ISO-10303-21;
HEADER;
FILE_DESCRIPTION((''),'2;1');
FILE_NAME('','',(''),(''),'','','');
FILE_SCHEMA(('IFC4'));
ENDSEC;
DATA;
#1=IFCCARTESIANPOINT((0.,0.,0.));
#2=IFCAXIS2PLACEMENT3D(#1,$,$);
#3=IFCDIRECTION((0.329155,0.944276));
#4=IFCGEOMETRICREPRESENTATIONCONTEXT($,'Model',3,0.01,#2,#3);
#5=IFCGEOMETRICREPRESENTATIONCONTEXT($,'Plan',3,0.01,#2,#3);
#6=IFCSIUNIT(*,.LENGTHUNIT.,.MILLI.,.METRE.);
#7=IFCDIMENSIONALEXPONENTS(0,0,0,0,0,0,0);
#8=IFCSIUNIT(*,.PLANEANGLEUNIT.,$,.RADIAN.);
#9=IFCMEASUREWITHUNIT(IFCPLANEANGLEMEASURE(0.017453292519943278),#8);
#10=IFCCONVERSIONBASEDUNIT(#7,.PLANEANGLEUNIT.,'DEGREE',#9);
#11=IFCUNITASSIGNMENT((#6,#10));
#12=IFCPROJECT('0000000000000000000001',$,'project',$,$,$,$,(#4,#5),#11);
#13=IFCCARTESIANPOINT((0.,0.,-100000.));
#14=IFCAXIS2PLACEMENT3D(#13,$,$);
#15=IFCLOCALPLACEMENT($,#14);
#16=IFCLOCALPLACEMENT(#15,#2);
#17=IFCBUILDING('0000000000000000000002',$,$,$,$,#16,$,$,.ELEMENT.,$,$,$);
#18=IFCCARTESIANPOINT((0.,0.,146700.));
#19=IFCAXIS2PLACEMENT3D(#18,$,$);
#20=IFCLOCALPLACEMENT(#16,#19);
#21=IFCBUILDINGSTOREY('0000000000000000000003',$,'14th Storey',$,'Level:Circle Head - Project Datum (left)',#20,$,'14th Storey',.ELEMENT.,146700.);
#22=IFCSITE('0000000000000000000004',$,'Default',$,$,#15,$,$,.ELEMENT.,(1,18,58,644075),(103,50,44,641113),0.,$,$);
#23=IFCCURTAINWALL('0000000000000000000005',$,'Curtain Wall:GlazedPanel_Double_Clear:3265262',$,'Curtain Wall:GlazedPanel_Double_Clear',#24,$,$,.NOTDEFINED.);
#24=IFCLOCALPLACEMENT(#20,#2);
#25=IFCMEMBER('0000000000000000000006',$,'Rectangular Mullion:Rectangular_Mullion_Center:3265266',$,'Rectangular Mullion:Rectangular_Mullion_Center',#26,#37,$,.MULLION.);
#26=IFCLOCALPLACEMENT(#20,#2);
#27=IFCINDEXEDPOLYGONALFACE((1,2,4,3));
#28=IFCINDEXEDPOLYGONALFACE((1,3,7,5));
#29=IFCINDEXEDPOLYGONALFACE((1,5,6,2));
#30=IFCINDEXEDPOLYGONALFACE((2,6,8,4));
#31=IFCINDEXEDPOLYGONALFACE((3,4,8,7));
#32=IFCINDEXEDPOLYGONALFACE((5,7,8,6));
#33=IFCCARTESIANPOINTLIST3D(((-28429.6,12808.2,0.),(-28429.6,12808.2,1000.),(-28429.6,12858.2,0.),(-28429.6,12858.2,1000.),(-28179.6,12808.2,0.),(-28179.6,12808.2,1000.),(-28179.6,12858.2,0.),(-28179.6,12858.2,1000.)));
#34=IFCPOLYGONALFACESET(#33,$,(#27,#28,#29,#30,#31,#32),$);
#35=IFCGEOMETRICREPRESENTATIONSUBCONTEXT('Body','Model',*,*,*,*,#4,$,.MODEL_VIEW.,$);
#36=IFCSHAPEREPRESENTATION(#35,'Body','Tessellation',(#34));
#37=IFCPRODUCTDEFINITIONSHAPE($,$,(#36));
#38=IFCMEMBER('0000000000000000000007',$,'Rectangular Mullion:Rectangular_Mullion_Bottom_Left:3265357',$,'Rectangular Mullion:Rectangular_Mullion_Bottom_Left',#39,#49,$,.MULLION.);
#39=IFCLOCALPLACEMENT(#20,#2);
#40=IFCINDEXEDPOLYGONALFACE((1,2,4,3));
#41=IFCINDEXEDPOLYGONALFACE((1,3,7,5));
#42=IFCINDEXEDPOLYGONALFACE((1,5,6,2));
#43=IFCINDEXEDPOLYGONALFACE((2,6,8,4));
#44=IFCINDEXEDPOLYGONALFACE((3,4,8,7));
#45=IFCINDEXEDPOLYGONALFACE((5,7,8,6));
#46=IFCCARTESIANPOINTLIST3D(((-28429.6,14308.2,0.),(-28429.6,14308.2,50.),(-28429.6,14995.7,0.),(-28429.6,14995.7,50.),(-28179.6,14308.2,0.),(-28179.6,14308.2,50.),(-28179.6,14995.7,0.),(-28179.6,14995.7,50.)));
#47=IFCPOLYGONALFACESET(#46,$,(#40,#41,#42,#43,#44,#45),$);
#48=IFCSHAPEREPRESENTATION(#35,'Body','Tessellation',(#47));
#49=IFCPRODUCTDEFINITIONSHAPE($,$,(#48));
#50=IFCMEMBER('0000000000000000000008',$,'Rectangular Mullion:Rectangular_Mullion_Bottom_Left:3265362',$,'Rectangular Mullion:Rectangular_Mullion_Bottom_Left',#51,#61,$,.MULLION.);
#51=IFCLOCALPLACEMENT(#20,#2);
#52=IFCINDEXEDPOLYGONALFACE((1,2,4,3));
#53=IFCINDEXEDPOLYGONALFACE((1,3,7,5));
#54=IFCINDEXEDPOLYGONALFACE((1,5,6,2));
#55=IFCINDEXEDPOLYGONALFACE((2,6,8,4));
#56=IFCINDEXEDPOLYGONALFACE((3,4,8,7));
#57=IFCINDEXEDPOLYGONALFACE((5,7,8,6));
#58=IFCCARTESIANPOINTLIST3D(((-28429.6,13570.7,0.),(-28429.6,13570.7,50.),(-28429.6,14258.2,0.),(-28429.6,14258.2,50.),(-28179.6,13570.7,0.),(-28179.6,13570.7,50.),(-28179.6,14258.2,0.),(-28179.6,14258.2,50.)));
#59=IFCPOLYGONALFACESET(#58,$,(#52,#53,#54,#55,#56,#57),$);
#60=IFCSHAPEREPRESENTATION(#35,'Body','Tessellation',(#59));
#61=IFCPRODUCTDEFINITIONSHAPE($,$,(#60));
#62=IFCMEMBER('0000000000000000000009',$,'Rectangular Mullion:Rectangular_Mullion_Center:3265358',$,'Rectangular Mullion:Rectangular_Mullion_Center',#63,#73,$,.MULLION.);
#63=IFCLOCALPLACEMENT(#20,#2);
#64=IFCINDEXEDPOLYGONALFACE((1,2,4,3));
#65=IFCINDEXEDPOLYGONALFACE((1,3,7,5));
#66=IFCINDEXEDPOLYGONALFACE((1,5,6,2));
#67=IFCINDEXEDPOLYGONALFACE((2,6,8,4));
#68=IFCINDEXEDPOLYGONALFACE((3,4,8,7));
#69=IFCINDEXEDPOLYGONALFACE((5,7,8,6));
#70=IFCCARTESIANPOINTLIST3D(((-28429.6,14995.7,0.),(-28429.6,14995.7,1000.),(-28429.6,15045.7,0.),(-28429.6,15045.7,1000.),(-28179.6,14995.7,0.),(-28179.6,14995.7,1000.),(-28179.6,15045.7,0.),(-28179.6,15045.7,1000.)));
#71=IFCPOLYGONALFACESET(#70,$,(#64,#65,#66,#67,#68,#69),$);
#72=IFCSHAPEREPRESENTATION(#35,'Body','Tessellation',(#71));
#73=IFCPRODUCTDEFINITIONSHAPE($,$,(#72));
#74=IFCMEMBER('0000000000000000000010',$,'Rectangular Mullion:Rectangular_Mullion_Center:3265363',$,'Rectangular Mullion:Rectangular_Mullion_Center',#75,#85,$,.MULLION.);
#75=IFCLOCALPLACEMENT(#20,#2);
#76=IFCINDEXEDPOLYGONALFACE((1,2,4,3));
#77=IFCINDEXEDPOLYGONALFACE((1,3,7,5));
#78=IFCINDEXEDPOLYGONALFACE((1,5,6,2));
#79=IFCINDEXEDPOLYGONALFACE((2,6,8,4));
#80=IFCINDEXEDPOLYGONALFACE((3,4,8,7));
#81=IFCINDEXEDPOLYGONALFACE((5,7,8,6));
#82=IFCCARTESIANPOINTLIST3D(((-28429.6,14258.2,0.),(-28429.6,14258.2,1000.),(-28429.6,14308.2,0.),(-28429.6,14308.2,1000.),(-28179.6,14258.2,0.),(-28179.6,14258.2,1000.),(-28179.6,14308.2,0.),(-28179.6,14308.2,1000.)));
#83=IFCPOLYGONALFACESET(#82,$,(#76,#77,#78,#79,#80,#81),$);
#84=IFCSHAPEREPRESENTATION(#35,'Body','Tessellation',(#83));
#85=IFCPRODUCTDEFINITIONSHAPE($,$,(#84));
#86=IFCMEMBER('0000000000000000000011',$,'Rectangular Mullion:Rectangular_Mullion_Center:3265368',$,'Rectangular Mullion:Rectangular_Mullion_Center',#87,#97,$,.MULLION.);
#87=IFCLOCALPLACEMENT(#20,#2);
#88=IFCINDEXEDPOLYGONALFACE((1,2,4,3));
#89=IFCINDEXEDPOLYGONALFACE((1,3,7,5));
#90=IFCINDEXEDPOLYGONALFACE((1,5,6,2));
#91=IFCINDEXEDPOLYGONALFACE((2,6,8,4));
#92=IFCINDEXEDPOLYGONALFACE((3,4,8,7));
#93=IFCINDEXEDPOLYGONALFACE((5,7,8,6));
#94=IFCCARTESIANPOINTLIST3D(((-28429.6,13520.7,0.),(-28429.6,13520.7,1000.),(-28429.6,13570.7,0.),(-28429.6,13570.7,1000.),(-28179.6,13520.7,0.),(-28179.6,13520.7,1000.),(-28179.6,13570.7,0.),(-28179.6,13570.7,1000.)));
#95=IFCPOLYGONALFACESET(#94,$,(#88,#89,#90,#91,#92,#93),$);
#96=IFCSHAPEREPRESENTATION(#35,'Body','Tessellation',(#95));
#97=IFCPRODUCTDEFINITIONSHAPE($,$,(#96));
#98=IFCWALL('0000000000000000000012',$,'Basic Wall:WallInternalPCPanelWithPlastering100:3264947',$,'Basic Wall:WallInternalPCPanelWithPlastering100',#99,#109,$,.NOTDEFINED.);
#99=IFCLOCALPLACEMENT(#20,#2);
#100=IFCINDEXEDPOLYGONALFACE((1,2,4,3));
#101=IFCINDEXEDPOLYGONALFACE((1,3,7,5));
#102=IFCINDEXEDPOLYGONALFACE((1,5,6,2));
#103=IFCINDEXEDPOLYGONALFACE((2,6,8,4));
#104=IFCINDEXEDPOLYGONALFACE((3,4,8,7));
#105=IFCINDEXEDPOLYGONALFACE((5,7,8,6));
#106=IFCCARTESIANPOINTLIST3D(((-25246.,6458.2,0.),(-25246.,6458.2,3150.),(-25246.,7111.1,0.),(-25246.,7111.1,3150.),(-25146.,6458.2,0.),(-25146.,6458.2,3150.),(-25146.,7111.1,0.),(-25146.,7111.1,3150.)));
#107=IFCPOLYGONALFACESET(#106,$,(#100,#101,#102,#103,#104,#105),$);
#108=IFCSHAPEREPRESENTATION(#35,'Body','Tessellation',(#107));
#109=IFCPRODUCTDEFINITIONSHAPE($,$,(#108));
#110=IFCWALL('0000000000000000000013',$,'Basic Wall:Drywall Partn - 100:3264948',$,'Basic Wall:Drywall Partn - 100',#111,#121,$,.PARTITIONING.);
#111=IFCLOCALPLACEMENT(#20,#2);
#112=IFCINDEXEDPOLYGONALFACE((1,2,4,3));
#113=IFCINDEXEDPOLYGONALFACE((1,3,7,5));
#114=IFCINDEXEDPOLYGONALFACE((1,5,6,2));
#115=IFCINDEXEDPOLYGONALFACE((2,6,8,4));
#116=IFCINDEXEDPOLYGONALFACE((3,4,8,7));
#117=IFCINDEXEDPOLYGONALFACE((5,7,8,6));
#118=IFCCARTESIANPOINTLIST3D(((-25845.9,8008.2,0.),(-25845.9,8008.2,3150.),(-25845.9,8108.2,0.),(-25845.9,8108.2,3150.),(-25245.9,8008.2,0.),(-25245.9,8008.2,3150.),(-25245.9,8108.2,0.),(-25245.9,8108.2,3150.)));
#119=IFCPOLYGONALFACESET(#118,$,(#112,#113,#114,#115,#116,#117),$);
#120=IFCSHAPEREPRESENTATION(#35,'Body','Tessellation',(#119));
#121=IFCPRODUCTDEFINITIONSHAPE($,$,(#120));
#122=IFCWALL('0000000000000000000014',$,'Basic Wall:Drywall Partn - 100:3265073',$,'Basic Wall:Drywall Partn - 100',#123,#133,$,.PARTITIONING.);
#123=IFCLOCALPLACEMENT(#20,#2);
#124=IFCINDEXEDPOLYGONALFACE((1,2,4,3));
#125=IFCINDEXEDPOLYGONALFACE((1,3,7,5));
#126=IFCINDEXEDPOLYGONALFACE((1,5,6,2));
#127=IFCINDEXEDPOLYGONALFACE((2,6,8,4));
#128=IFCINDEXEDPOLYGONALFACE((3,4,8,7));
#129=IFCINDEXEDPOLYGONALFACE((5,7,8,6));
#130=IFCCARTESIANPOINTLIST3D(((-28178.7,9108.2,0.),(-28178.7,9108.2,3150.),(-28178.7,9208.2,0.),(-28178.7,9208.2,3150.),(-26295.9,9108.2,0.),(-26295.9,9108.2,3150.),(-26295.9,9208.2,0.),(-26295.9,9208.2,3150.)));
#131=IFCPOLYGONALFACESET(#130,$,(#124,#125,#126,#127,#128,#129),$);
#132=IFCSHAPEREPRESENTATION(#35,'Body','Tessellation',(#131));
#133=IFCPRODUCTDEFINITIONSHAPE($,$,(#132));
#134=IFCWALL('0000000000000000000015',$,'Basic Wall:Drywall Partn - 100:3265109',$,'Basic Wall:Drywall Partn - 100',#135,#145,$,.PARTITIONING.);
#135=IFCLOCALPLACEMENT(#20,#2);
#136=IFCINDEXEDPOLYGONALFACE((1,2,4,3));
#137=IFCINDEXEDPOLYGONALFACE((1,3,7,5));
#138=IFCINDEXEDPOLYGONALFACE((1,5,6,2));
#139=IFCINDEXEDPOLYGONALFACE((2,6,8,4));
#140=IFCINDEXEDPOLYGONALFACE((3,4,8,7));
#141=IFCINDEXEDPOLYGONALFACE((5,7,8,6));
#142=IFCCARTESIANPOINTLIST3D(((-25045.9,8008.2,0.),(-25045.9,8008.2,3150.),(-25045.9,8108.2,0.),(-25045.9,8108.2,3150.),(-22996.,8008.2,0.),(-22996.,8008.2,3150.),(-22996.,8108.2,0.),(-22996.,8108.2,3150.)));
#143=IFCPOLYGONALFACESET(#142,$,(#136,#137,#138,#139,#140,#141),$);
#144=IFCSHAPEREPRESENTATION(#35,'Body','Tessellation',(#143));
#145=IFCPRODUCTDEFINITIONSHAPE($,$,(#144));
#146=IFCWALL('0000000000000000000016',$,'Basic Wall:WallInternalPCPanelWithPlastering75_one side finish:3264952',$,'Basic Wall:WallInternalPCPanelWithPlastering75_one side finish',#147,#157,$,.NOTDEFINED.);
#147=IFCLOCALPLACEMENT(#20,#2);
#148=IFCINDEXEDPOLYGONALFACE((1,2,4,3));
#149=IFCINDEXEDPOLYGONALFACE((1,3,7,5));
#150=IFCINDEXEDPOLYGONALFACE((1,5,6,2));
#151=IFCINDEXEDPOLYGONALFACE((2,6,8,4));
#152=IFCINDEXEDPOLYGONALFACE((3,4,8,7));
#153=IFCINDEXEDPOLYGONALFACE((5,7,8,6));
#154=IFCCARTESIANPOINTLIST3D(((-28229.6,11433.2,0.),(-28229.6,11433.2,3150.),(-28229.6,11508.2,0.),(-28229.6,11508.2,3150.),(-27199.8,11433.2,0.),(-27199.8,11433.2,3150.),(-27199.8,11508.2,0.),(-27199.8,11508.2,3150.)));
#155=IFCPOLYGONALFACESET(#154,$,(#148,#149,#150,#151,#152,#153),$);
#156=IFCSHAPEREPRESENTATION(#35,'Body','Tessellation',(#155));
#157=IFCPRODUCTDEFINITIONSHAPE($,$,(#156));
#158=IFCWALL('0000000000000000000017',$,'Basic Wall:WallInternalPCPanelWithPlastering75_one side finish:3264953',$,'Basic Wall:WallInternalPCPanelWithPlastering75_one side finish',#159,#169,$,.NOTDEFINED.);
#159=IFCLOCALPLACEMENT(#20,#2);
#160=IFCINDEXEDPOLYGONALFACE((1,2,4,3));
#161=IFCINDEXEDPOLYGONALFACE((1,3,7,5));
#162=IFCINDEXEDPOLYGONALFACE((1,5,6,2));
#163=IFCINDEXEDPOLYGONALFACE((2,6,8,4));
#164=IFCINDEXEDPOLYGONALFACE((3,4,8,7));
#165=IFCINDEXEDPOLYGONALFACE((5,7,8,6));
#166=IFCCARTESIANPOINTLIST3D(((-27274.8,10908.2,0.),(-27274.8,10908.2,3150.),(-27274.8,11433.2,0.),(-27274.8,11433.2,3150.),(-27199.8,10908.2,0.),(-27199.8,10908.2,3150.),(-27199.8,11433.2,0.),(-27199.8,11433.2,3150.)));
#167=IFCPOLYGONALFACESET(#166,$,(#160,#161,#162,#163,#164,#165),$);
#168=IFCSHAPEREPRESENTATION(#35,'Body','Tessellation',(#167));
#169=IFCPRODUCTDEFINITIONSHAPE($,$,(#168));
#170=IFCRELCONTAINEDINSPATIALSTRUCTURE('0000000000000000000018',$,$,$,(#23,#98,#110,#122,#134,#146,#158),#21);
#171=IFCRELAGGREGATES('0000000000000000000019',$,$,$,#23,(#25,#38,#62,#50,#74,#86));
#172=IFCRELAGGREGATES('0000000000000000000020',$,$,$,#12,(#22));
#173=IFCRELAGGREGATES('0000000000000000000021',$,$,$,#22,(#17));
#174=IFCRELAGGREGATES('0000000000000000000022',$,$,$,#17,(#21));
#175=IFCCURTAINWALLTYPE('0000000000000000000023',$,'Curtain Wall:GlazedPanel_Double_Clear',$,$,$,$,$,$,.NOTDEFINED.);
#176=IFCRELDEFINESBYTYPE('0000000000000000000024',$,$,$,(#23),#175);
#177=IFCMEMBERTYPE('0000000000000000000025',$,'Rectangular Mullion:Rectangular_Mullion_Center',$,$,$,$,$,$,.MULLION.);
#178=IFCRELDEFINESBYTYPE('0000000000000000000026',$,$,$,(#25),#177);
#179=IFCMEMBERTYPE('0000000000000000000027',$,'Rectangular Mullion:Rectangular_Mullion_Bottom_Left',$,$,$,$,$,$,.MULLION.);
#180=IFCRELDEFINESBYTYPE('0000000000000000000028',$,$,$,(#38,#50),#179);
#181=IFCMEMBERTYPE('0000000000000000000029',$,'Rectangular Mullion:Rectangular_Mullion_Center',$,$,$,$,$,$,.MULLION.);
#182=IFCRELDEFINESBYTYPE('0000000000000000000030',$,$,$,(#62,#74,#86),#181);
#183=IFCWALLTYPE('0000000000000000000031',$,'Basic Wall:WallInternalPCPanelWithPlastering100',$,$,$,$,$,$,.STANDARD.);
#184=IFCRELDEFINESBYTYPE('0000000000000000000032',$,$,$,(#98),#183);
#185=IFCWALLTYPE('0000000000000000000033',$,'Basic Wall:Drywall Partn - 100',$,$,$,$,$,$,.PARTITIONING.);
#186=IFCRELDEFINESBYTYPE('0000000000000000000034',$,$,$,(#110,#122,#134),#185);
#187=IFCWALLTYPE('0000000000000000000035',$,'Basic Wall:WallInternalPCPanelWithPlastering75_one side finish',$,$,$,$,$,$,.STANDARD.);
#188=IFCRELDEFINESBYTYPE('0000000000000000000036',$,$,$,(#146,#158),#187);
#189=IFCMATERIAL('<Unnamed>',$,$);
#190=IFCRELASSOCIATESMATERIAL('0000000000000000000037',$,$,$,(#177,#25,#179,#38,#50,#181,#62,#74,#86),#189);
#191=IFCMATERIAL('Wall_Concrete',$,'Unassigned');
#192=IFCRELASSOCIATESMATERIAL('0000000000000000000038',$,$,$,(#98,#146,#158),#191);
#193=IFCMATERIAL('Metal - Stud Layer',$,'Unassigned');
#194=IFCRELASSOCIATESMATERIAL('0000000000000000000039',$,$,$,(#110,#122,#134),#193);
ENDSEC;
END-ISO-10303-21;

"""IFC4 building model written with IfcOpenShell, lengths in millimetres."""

from ifc_helpers import new_model, entity, si_unit, converted_unit, direction, frame, origin, place, context, subcontext, project, spatial, indexed_curve, outline, extrude, source, transform, mapped, material, type_object, type_shapes, element, aggregate, save


model = new_model("IFC4")

# Units and contexts
model_context = context("Model", 3, precision=0.01, world=origin(), true_north=direction((0.329155, 0.944276)))
plan_context = context("Plan", 3, precision=0.01, world=origin(), true_north=direction((0.329155, 0.944276)))
body_context = subcontext(model_context, "Body", "Model", "MODEL_VIEW")
ifc_project = project(units=[si_unit("LENGTHUNIT", "METRE", prefix="MILLI"), converted_unit("PLANEANGLEUNIT", "DEGREE", entity("IfcPlaneAngleMeasure", 0.017453292519943278), si_unit("PLANEANGLEUNIT", "RADIAN"), dimensions=[0, 0, 0, 0, 0, 0, 0])], contexts=[model_context, plan_context])

# Site, building, storey
site_placement = place(None, frame((0.0, 0.0, -100000.0)))
site = spatial("IfcSite", under=ifc_project, at=site_placement, Name="Default", CompositionType="ELEMENT", RefLatitude=(1, 18, 58, 644075), RefLongitude=(103, 50, 44, 641113), RefElevation=0.0)
building_placement = place(site_placement, origin())
building = spatial("IfcBuilding", under=site, at=building_placement, CompositionType="ELEMENT")
storey_placement = place(building_placement, frame((0.0, 0.0, 146700.0)))
storey = spatial("IfcBuildingStorey", under=building, at=storey_placement, Name="14th Storey", ObjectType="Level:Circle Head - Project Datum (left)", LongName="14th Storey", CompositionType="ELEMENT", Elevation=146700.0)

# Shared definitions
curtain_wall_type = type_object("IfcCurtainWallType", Name="Curtain Wall:GlazedPanel_Double_Clear", PredefinedType="NOTDEFINED")
ifc_material_1 = material(Name="<Unnamed>")

# Curtain wall, members
curtain_wall_1_placement = place(storey_placement, frame((0.0, 0.0, -146700.0)))
curtain_wall_1 = element("IfcCurtainWall", 1, at=curtain_wall_1_placement, inside=storey, type_object=curtain_wall_type, Name="Curtain Wall:GlazedPanel_Double_Clear:3265262", ObjectType="Curtain Wall:GlazedPanel_Double_Clear", PredefinedType="NOTDEFINED")
member_type_1 = type_object("IfcMemberType", Name="Rectangular Mullion:Rectangular_Mullion_Center", PredefinedType="MULLION", material=ifc_material_1)
shared_shape_1 = source(origin(), body_context, "Body", "SweptSolid", [
    extrude(outline(indexed_curve([(-25.0, -125.0), (25.0, -125.0), (25.0, 125.0), (-25.0, 125.0), (-25.0, -125.0)], self_intersect=False)), frame((-25.0, 0.0, -1000.0), z_axis=(0.0, 0.0, 1.0), x_axis=(-1.0, 0.0, 0.0)), (0.0, 0.0, 1.0), 1000.0),
])
type_shapes(member_type_1, [shared_shape_1])
member_1_placement = place(curtain_wall_1_placement, frame((-28304.6, 12808.2, 146700.0), z_axis=(0.0, 0.0, -1.0), x_axis=(0.0, -1.0, 0.0)))
member_1 = element("IfcMember", 2, at=member_1_placement, type_object=member_type_1, material=ifc_material_1, Name="Rectangular Mullion:Rectangular_Mullion_Center:3265266", ObjectType="Rectangular Mullion:Rectangular_Mullion_Center", PredefinedType="MULLION", context=body_context, shape_type="MappedRepresentation", body=[
    mapped(shared_shape_1, transform((0.0, 0.0, 0.0), scale=1.0)),
])
member_type_2 = type_object("IfcMemberType", Name="Rectangular Mullion:Rectangular_Mullion_Bottom_Left", PredefinedType="MULLION", material=ifc_material_1)
shared_shape_2 = source(origin(), body_context, "Body", "SweptSolid", [
    extrude(outline(indexed_curve([(-25.0, -125.0), (25.0, -125.0), (25.0, 125.0), (-25.0, 125.0), (-25.0, -125.0)], self_intersect=False)), frame((-25.0, 0.0, -687.5), z_axis=(0.0, 0.0, 1.0), x_axis=(-1.0, 0.0, 0.0)), (0.0, 0.0, 1.0), 687.5),
])
type_shapes(member_type_2, [shared_shape_2])
member_2_placement = place(curtain_wall_1_placement, frame((-28304.6, 14995.7, 146700.0), z_axis=(0.0, 1.0, 0.0), x_axis=(0.0, 0.0, -1.0)))
member_2 = element("IfcMember", 3, at=member_2_placement, type_object=member_type_2, material=ifc_material_1, Name="Rectangular Mullion:Rectangular_Mullion_Bottom_Left:3265357", ObjectType="Rectangular Mullion:Rectangular_Mullion_Bottom_Left", PredefinedType="MULLION", context=body_context, shape_type="MappedRepresentation", body=[
    mapped(shared_shape_2, transform((0.0, 0.0, 0.0), scale=1.0)),
])
member_3_placement = place(curtain_wall_1_placement, frame((-28304.6, 14258.2, 146700.0), z_axis=(0.0, 1.0, 0.0), x_axis=(0.0, 0.0, -1.0)))
member_3 = element("IfcMember", 4, at=member_3_placement, type_object=member_type_2, material=ifc_material_1, Name="Rectangular Mullion:Rectangular_Mullion_Bottom_Left:3265362", ObjectType="Rectangular Mullion:Rectangular_Mullion_Bottom_Left", PredefinedType="MULLION", context=body_context, shape_type="MappedRepresentation", body=[
    mapped(shared_shape_2, transform((0.0, 0.0, 0.0), scale=1.0)),
])
member_type_3 = type_object("IfcMemberType", Name="Rectangular Mullion:Rectangular_Mullion_Center", PredefinedType="MULLION", material=ifc_material_1)
shared_shape_3 = source(origin(), body_context, "Body", "SweptSolid", [
    extrude(outline(indexed_curve([(-25.0, -125.0), (25.0, -125.0), (25.0, 125.0), (-25.0, 125.0), (-25.0, -125.0)], self_intersect=False)), frame((0.0, 0.0, -1000.0), z_axis=(0.0, 0.0, 1.0), x_axis=(-1.0, 0.0, 0.0)), (0.0, 0.0, 1.0), 1000.0),
])
type_shapes(member_type_3, [shared_shape_3])
member_4_placement = place(curtain_wall_1_placement, frame((-28304.6, 15020.7, 146700.0), z_axis=(0.0, 0.0, -1.0), x_axis=(0.0, -1.0, 0.0)))
member_4 = element("IfcMember", 5, at=member_4_placement, type_object=member_type_3, material=ifc_material_1, Name="Rectangular Mullion:Rectangular_Mullion_Center:3265358", ObjectType="Rectangular Mullion:Rectangular_Mullion_Center", PredefinedType="MULLION", context=body_context, shape_type="MappedRepresentation", body=[
    mapped(shared_shape_3, transform((0.0, 0.0, 0.0), scale=1.0)),
])
member_5_placement = place(curtain_wall_1_placement, frame((-28304.6, 14283.2, 146700.0), z_axis=(0.0, 0.0, -1.0), x_axis=(0.0, -1.0, 0.0)))
member_5 = element("IfcMember", 6, at=member_5_placement, type_object=member_type_3, material=ifc_material_1, Name="Rectangular Mullion:Rectangular_Mullion_Center:3265363", ObjectType="Rectangular Mullion:Rectangular_Mullion_Center", PredefinedType="MULLION", context=body_context, shape_type="MappedRepresentation", body=[
    mapped(shared_shape_3, transform((0.0, 0.0, 0.0), scale=1.0)),
])
member_6_placement = place(curtain_wall_1_placement, frame((-28304.6, 13545.7, 146700.0), z_axis=(0.0, 0.0, -1.0), x_axis=(0.0, -1.0, 0.0)))
member_6 = element("IfcMember", 7, at=member_6_placement, type_object=member_type_3, material=ifc_material_1, Name="Rectangular Mullion:Rectangular_Mullion_Center:3265368", ObjectType="Rectangular Mullion:Rectangular_Mullion_Center", PredefinedType="MULLION", context=body_context, shape_type="MappedRepresentation", body=[
    mapped(shared_shape_3, transform((0.0, 0.0, 0.0), scale=1.0)),
])
aggregate(curtain_wall_1, [member_1, member_2, member_4, member_3, member_5, member_6])

# Walls
ifc_material_2 = material(Name="Wall_Concrete", Category="Unassigned")
wall_type_1 = type_object("IfcWallType", Name="Basic Wall:WallInternalPCPanelWithPlastering100", PredefinedType="STANDARD")
wall_1_placement = place(storey_placement, frame((-25196.0, 6458.2, 0.0), z_axis=(0.0, 0.0, 1.0), x_axis=(0.0, 1.0, 0.0)))
element("IfcWall", 8, at=wall_1_placement, inside=storey, type_object=wall_type_1, material=ifc_material_2, Name="Basic Wall:WallInternalPCPanelWithPlastering100:3264947", ObjectType="Basic Wall:WallInternalPCPanelWithPlastering100", PredefinedType="NOTDEFINED", context=body_context, shape_type="SweptSolid", body=[
    extrude(outline(indexed_curve([(652.9, 50.0), (0.0, 50.0), (0.0, -50.0), (652.9, -50.0), (652.9, 50.0)], self_intersect=False)), origin(), (0.0, 0.0, 1.0), 3150.0),
])
ifc_material_3 = material(Name="Metal - Stud Layer", Category="Unassigned")
wall_type_2 = type_object("IfcWallType", Name="Basic Wall:Drywall Partn - 100", PredefinedType="PARTITIONING")
wall_2_placement = place(storey_placement, frame((-25845.9, 8058.2, 0.0)))
element("IfcWall", 9, at=wall_2_placement, inside=storey, type_object=wall_type_2, material=ifc_material_3, Name="Basic Wall:Drywall Partn - 100:3264948", ObjectType="Basic Wall:Drywall Partn - 100", PredefinedType="PARTITIONING", context=body_context, shape_type="SweptSolid", body=[
    extrude(outline(indexed_curve([(600.0, 50.0), (0.0, 50.0), (0.0, -50.0), (600.0, -50.0), (600.0, 50.0)], self_intersect=False)), origin(), (0.0, 0.0, 1.0), 3150.0),
])
wall_3_placement = place(storey_placement, frame((-26295.9, 9158.2, 0.0), z_axis=(0.0, 0.0, 1.0), x_axis=(-1.0, -0.000014, 0.0)))
element("IfcWall", 10, at=wall_3_placement, inside=storey, type_object=wall_type_2, material=ifc_material_3, Name="Basic Wall:Drywall Partn - 100:3265073", ObjectType="Basic Wall:Drywall Partn - 100", PredefinedType="PARTITIONING", context=body_context, shape_type="SweptSolid", body=[
    extrude(outline(indexed_curve([(1882.8, 50.0), (0.0, 50.0), (0.0, -50.0), (1882.8, -50.0), (1882.8, 50.0)], self_intersect=False)), origin(), (0.0, 0.0, 1.0), 3150.0),
])
wall_4_placement = place(storey_placement, frame((-25045.9, 8058.2, 0.0)))
element("IfcWall", 11, at=wall_4_placement, inside=storey, type_object=wall_type_2, material=ifc_material_3, Name="Basic Wall:Drywall Partn - 100:3265109", ObjectType="Basic Wall:Drywall Partn - 100", PredefinedType="PARTITIONING", context=body_context, shape_type="SweptSolid", body=[
    extrude(outline(indexed_curve([(2049.9, 50.0), (0.0, 50.0), (0.0, -50.0), (2049.9, -50.0), (2049.9, 50.0)], self_intersect=False)), origin(), (0.0, 0.0, 1.0), 3150.0),
])
wall_type_3 = type_object("IfcWallType", Name="Basic Wall:WallInternalPCPanelWithPlastering75_one side finish", PredefinedType="STANDARD")
wall_5_placement = place(storey_placement, frame((-28229.6, 11470.7, 0.0)))
element("IfcWall", 12, at=wall_5_placement, inside=storey, type_object=wall_type_3, material=ifc_material_2, Name="Basic Wall:WallInternalPCPanelWithPlastering75_one side finish:3264952", ObjectType="Basic Wall:WallInternalPCPanelWithPlastering75_one side finish", PredefinedType="NOTDEFINED", context=body_context, shape_type="SweptSolid", body=[
    extrude(outline(indexed_curve([(1029.8, 37.5), (0.0, 37.5), (0.0, -37.5), (1029.8, -37.5), (1029.8, 37.5)], self_intersect=False)), origin(), (0.0, 0.0, 1.0), 3150.0),
])
wall_6_placement = place(storey_placement, frame((-27237.3, 11433.2, 0.0), z_axis=(0.0, 0.0, 1.0), x_axis=(0.0, -1.0, 0.0)))
element("IfcWall", 13, at=wall_6_placement, inside=storey, type_object=wall_type_3, material=ifc_material_2, Name="Basic Wall:WallInternalPCPanelWithPlastering75_one side finish:3264953", ObjectType="Basic Wall:WallInternalPCPanelWithPlastering75_one side finish", PredefinedType="NOTDEFINED", context=body_context, shape_type="SweptSolid", body=[
    extrude(outline(indexed_curve([(525.0, 37.5), (0.0, 37.5), (0.0, -37.5), (525.0, -37.5), (525.0, 37.5)], self_intersect=False)), origin(), (0.0, 0.0, 1.0), 3150.0),
])

save(model, "model.ifc")
